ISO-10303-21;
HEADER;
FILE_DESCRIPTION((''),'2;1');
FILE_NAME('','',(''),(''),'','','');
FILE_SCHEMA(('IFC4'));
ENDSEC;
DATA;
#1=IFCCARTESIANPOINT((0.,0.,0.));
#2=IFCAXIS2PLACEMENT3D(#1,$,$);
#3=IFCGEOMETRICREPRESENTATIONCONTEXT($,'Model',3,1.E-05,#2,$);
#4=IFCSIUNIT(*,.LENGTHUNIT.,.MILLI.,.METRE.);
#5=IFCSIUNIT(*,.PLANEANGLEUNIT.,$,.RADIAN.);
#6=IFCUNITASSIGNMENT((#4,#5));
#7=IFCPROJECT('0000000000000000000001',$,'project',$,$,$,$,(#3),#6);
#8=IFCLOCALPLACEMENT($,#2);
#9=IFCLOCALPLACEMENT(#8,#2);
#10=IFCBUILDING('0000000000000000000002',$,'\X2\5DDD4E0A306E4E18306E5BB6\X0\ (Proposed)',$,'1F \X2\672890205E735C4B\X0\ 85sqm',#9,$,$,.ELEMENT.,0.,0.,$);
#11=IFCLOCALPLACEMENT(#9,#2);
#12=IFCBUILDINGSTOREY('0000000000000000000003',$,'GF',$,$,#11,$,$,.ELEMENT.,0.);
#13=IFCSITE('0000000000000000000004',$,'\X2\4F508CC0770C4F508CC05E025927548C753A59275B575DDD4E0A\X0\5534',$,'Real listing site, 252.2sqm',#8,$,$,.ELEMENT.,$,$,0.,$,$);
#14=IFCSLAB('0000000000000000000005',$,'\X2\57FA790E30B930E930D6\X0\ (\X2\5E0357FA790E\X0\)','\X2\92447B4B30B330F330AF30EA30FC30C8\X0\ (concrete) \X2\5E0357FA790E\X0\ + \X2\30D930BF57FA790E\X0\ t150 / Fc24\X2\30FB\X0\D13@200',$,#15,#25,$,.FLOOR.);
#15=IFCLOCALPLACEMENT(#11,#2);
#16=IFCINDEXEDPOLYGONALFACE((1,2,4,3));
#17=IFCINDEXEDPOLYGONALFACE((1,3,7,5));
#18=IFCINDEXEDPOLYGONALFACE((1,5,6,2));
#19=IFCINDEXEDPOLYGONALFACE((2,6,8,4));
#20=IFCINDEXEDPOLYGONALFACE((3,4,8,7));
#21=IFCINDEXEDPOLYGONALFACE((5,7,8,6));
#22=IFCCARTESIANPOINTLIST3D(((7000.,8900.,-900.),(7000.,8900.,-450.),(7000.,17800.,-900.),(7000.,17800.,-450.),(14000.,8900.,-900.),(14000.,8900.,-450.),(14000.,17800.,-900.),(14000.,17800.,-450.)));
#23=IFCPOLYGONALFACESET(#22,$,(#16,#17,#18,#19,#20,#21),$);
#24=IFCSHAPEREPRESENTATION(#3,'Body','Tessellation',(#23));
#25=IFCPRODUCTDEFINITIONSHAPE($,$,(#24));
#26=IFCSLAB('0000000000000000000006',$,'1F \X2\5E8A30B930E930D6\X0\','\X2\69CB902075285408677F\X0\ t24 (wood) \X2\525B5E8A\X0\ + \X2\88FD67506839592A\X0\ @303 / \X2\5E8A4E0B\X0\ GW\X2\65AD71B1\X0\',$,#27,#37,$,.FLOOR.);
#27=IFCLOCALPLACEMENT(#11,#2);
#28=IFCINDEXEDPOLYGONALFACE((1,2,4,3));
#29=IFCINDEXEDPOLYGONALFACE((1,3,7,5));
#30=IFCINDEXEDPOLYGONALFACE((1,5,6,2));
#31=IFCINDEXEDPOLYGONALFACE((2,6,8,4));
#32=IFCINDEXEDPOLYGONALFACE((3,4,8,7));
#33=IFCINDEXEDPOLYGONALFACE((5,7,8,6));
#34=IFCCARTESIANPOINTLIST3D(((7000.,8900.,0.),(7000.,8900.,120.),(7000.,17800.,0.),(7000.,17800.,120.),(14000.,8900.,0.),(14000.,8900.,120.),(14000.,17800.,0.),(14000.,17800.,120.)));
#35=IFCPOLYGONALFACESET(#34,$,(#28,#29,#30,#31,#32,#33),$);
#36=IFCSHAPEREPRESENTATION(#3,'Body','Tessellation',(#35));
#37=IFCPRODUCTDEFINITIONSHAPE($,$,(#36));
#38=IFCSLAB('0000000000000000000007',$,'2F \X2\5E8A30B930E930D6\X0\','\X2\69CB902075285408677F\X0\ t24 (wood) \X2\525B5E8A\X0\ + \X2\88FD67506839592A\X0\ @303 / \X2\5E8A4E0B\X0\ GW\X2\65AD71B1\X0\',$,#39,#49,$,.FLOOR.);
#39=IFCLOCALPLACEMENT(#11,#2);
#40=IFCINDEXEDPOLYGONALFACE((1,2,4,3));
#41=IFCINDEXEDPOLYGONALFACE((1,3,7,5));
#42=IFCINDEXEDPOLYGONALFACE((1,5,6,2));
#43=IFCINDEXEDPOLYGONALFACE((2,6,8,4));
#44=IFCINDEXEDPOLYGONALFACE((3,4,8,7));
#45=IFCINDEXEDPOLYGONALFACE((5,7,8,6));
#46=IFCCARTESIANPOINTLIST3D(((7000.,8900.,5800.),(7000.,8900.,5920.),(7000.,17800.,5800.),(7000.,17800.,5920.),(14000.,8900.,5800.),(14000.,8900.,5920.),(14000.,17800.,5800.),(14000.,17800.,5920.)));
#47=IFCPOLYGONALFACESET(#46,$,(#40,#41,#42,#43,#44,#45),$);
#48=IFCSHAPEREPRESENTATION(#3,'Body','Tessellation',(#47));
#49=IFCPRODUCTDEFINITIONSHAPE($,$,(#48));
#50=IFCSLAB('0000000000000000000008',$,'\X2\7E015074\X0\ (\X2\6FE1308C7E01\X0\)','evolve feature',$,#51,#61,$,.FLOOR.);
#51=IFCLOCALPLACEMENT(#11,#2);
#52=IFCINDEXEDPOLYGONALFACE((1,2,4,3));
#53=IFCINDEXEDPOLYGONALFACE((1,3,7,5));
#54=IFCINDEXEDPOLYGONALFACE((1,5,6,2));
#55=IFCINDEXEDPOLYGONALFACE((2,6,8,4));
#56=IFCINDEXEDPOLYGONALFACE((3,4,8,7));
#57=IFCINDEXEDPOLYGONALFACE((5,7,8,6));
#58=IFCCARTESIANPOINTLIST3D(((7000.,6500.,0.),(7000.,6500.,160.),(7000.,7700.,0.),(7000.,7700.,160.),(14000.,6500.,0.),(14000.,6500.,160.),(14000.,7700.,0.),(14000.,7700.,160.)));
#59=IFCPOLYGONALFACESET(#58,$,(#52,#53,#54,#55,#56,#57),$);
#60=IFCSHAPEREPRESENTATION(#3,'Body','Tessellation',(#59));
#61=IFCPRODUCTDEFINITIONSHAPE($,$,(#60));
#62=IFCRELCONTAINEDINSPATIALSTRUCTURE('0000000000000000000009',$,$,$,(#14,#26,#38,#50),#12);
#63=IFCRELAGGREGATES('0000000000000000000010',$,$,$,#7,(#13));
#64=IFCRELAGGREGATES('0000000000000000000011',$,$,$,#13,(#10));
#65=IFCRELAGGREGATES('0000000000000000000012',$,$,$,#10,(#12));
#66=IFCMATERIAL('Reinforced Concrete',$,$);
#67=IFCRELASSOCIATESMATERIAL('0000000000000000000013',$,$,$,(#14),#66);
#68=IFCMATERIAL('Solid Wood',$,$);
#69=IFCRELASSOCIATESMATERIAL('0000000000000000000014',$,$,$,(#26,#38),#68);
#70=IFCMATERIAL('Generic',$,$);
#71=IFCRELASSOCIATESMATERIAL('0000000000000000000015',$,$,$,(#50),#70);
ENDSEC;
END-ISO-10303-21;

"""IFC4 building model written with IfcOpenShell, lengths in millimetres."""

from ifc_helpers import new_model, si_unit, frame, frame_2d, origin, place, context, project, spatial, rectangle, extrude, material, element, save


model = new_model("IFC4")

# Units and contexts
model_context = context("Model", 3, precision=1e-05, world=origin())
ifc_project = project(units=[si_unit("LENGTHUNIT", "METRE", prefix="MILLI"), si_unit("PLANEANGLEUNIT", "RADIAN")], contexts=[model_context])

# Site, building, storey
site_placement = place(None, origin())
site = spatial("IfcSite", under=ifc_project, at=site_placement, Name="佐賀県佐賀市大和町大字川上5534", ObjectType="Real listing site, 252.2sqm", CompositionType="ELEMENT", RefElevation=0.0)
building_placement = place(site_placement, origin())
building = spatial("IfcBuilding", under=site, at=building_placement, Name="川上の丘の家 (Proposed)", ObjectType="1F 木造平屋 85sqm", CompositionType="ELEMENT", ElevationOfRefHeight=0.0, ElevationOfTerrain=0.0)
storey_placement = place(building_placement, origin())
storey = spatial("IfcBuildingStorey", under=building, at=storey_placement, Name="GF", CompositionType="ELEMENT", Elevation=0.0)

# Slabs
ifc_material_1 = material(Name="Reinforced Concrete")
slab_1_placement = place(storey_placement, frame((3500.0, 4450.0, -450.0)))
element("IfcSlab", 1, at=slab_1_placement, inside=storey, material=ifc_material_1, Name="基礎スラブ (布基礎)", Description="鉄筋コンクリート (concrete) 布基礎 + ベタ基礎 t150 / Fc24・D13@200", PredefinedType="FLOOR", context=model_context, shape_type="SweptSolid", body=[
    extrude(rectangle(XDim=7000.0, YDim=8900.0, at=frame_2d((3500.0, 4450.0))), frame((3500.0, 4450.0, -450.0)), (0.0, 0.0, 1.0), 450.0),
])
ifc_material_2 = material(Name="Solid Wood")
slab_2_placement = place(storey_placement, frame((3500.0, 4450.0, 0.0)))
element("IfcSlab", 2, at=slab_2_placement, inside=storey, material=ifc_material_2, Name="1F 床スラブ", Description="構造用合板 t24 (wood) 剛床 + 製材根太 @303 / 床下 GW断熱", PredefinedType="FLOOR", context=model_context, shape_type="SweptSolid", body=[
    extrude(rectangle(XDim=7000.0, YDim=8900.0, at=frame_2d((3500.0, 4450.0))), frame((3500.0, 4450.0, 0.0)), (0.0, 0.0, 1.0), 120.0),
])
slab_3_placement = place(storey_placement, frame((3500.0, 4450.0, 2900.0)))
element("IfcSlab", 3, at=slab_3_placement, inside=storey, material=ifc_material_2, Name="2F 床スラブ", Description="構造用合板 t24 (wood) 剛床 + 製材根太 @303 / 床下 GW断熱", PredefinedType="FLOOR", context=model_context, shape_type="SweptSolid", body=[
    extrude(rectangle(XDim=7000.0, YDim=8900.0, at=frame_2d((3500.0, 4450.0))), frame((3500.0, 4450.0, 2900.0)), (0.0, 0.0, 1.0), 120.0),
])
ifc_material_3 = material(Name="Generic")
slab_4_placement = place(storey_placement, frame((3500.0, 3250.0, 0.0)))
element("IfcSlab", 4, at=slab_4_placement, inside=storey, material=ifc_material_3, Name="縁側 (濡れ縁)", Description="evolve feature", PredefinedType="FLOOR", context=model_context, shape_type="SweptSolid", body=[
    extrude(rectangle(XDim=7000.0, YDim=1200.0, at=frame_2d((3500.0, 600.0))), frame((3500.0, 3250.0, 0.0)), (0.0, 0.0, 1.0), 160.0),
])

save(model, "model.ifc")
